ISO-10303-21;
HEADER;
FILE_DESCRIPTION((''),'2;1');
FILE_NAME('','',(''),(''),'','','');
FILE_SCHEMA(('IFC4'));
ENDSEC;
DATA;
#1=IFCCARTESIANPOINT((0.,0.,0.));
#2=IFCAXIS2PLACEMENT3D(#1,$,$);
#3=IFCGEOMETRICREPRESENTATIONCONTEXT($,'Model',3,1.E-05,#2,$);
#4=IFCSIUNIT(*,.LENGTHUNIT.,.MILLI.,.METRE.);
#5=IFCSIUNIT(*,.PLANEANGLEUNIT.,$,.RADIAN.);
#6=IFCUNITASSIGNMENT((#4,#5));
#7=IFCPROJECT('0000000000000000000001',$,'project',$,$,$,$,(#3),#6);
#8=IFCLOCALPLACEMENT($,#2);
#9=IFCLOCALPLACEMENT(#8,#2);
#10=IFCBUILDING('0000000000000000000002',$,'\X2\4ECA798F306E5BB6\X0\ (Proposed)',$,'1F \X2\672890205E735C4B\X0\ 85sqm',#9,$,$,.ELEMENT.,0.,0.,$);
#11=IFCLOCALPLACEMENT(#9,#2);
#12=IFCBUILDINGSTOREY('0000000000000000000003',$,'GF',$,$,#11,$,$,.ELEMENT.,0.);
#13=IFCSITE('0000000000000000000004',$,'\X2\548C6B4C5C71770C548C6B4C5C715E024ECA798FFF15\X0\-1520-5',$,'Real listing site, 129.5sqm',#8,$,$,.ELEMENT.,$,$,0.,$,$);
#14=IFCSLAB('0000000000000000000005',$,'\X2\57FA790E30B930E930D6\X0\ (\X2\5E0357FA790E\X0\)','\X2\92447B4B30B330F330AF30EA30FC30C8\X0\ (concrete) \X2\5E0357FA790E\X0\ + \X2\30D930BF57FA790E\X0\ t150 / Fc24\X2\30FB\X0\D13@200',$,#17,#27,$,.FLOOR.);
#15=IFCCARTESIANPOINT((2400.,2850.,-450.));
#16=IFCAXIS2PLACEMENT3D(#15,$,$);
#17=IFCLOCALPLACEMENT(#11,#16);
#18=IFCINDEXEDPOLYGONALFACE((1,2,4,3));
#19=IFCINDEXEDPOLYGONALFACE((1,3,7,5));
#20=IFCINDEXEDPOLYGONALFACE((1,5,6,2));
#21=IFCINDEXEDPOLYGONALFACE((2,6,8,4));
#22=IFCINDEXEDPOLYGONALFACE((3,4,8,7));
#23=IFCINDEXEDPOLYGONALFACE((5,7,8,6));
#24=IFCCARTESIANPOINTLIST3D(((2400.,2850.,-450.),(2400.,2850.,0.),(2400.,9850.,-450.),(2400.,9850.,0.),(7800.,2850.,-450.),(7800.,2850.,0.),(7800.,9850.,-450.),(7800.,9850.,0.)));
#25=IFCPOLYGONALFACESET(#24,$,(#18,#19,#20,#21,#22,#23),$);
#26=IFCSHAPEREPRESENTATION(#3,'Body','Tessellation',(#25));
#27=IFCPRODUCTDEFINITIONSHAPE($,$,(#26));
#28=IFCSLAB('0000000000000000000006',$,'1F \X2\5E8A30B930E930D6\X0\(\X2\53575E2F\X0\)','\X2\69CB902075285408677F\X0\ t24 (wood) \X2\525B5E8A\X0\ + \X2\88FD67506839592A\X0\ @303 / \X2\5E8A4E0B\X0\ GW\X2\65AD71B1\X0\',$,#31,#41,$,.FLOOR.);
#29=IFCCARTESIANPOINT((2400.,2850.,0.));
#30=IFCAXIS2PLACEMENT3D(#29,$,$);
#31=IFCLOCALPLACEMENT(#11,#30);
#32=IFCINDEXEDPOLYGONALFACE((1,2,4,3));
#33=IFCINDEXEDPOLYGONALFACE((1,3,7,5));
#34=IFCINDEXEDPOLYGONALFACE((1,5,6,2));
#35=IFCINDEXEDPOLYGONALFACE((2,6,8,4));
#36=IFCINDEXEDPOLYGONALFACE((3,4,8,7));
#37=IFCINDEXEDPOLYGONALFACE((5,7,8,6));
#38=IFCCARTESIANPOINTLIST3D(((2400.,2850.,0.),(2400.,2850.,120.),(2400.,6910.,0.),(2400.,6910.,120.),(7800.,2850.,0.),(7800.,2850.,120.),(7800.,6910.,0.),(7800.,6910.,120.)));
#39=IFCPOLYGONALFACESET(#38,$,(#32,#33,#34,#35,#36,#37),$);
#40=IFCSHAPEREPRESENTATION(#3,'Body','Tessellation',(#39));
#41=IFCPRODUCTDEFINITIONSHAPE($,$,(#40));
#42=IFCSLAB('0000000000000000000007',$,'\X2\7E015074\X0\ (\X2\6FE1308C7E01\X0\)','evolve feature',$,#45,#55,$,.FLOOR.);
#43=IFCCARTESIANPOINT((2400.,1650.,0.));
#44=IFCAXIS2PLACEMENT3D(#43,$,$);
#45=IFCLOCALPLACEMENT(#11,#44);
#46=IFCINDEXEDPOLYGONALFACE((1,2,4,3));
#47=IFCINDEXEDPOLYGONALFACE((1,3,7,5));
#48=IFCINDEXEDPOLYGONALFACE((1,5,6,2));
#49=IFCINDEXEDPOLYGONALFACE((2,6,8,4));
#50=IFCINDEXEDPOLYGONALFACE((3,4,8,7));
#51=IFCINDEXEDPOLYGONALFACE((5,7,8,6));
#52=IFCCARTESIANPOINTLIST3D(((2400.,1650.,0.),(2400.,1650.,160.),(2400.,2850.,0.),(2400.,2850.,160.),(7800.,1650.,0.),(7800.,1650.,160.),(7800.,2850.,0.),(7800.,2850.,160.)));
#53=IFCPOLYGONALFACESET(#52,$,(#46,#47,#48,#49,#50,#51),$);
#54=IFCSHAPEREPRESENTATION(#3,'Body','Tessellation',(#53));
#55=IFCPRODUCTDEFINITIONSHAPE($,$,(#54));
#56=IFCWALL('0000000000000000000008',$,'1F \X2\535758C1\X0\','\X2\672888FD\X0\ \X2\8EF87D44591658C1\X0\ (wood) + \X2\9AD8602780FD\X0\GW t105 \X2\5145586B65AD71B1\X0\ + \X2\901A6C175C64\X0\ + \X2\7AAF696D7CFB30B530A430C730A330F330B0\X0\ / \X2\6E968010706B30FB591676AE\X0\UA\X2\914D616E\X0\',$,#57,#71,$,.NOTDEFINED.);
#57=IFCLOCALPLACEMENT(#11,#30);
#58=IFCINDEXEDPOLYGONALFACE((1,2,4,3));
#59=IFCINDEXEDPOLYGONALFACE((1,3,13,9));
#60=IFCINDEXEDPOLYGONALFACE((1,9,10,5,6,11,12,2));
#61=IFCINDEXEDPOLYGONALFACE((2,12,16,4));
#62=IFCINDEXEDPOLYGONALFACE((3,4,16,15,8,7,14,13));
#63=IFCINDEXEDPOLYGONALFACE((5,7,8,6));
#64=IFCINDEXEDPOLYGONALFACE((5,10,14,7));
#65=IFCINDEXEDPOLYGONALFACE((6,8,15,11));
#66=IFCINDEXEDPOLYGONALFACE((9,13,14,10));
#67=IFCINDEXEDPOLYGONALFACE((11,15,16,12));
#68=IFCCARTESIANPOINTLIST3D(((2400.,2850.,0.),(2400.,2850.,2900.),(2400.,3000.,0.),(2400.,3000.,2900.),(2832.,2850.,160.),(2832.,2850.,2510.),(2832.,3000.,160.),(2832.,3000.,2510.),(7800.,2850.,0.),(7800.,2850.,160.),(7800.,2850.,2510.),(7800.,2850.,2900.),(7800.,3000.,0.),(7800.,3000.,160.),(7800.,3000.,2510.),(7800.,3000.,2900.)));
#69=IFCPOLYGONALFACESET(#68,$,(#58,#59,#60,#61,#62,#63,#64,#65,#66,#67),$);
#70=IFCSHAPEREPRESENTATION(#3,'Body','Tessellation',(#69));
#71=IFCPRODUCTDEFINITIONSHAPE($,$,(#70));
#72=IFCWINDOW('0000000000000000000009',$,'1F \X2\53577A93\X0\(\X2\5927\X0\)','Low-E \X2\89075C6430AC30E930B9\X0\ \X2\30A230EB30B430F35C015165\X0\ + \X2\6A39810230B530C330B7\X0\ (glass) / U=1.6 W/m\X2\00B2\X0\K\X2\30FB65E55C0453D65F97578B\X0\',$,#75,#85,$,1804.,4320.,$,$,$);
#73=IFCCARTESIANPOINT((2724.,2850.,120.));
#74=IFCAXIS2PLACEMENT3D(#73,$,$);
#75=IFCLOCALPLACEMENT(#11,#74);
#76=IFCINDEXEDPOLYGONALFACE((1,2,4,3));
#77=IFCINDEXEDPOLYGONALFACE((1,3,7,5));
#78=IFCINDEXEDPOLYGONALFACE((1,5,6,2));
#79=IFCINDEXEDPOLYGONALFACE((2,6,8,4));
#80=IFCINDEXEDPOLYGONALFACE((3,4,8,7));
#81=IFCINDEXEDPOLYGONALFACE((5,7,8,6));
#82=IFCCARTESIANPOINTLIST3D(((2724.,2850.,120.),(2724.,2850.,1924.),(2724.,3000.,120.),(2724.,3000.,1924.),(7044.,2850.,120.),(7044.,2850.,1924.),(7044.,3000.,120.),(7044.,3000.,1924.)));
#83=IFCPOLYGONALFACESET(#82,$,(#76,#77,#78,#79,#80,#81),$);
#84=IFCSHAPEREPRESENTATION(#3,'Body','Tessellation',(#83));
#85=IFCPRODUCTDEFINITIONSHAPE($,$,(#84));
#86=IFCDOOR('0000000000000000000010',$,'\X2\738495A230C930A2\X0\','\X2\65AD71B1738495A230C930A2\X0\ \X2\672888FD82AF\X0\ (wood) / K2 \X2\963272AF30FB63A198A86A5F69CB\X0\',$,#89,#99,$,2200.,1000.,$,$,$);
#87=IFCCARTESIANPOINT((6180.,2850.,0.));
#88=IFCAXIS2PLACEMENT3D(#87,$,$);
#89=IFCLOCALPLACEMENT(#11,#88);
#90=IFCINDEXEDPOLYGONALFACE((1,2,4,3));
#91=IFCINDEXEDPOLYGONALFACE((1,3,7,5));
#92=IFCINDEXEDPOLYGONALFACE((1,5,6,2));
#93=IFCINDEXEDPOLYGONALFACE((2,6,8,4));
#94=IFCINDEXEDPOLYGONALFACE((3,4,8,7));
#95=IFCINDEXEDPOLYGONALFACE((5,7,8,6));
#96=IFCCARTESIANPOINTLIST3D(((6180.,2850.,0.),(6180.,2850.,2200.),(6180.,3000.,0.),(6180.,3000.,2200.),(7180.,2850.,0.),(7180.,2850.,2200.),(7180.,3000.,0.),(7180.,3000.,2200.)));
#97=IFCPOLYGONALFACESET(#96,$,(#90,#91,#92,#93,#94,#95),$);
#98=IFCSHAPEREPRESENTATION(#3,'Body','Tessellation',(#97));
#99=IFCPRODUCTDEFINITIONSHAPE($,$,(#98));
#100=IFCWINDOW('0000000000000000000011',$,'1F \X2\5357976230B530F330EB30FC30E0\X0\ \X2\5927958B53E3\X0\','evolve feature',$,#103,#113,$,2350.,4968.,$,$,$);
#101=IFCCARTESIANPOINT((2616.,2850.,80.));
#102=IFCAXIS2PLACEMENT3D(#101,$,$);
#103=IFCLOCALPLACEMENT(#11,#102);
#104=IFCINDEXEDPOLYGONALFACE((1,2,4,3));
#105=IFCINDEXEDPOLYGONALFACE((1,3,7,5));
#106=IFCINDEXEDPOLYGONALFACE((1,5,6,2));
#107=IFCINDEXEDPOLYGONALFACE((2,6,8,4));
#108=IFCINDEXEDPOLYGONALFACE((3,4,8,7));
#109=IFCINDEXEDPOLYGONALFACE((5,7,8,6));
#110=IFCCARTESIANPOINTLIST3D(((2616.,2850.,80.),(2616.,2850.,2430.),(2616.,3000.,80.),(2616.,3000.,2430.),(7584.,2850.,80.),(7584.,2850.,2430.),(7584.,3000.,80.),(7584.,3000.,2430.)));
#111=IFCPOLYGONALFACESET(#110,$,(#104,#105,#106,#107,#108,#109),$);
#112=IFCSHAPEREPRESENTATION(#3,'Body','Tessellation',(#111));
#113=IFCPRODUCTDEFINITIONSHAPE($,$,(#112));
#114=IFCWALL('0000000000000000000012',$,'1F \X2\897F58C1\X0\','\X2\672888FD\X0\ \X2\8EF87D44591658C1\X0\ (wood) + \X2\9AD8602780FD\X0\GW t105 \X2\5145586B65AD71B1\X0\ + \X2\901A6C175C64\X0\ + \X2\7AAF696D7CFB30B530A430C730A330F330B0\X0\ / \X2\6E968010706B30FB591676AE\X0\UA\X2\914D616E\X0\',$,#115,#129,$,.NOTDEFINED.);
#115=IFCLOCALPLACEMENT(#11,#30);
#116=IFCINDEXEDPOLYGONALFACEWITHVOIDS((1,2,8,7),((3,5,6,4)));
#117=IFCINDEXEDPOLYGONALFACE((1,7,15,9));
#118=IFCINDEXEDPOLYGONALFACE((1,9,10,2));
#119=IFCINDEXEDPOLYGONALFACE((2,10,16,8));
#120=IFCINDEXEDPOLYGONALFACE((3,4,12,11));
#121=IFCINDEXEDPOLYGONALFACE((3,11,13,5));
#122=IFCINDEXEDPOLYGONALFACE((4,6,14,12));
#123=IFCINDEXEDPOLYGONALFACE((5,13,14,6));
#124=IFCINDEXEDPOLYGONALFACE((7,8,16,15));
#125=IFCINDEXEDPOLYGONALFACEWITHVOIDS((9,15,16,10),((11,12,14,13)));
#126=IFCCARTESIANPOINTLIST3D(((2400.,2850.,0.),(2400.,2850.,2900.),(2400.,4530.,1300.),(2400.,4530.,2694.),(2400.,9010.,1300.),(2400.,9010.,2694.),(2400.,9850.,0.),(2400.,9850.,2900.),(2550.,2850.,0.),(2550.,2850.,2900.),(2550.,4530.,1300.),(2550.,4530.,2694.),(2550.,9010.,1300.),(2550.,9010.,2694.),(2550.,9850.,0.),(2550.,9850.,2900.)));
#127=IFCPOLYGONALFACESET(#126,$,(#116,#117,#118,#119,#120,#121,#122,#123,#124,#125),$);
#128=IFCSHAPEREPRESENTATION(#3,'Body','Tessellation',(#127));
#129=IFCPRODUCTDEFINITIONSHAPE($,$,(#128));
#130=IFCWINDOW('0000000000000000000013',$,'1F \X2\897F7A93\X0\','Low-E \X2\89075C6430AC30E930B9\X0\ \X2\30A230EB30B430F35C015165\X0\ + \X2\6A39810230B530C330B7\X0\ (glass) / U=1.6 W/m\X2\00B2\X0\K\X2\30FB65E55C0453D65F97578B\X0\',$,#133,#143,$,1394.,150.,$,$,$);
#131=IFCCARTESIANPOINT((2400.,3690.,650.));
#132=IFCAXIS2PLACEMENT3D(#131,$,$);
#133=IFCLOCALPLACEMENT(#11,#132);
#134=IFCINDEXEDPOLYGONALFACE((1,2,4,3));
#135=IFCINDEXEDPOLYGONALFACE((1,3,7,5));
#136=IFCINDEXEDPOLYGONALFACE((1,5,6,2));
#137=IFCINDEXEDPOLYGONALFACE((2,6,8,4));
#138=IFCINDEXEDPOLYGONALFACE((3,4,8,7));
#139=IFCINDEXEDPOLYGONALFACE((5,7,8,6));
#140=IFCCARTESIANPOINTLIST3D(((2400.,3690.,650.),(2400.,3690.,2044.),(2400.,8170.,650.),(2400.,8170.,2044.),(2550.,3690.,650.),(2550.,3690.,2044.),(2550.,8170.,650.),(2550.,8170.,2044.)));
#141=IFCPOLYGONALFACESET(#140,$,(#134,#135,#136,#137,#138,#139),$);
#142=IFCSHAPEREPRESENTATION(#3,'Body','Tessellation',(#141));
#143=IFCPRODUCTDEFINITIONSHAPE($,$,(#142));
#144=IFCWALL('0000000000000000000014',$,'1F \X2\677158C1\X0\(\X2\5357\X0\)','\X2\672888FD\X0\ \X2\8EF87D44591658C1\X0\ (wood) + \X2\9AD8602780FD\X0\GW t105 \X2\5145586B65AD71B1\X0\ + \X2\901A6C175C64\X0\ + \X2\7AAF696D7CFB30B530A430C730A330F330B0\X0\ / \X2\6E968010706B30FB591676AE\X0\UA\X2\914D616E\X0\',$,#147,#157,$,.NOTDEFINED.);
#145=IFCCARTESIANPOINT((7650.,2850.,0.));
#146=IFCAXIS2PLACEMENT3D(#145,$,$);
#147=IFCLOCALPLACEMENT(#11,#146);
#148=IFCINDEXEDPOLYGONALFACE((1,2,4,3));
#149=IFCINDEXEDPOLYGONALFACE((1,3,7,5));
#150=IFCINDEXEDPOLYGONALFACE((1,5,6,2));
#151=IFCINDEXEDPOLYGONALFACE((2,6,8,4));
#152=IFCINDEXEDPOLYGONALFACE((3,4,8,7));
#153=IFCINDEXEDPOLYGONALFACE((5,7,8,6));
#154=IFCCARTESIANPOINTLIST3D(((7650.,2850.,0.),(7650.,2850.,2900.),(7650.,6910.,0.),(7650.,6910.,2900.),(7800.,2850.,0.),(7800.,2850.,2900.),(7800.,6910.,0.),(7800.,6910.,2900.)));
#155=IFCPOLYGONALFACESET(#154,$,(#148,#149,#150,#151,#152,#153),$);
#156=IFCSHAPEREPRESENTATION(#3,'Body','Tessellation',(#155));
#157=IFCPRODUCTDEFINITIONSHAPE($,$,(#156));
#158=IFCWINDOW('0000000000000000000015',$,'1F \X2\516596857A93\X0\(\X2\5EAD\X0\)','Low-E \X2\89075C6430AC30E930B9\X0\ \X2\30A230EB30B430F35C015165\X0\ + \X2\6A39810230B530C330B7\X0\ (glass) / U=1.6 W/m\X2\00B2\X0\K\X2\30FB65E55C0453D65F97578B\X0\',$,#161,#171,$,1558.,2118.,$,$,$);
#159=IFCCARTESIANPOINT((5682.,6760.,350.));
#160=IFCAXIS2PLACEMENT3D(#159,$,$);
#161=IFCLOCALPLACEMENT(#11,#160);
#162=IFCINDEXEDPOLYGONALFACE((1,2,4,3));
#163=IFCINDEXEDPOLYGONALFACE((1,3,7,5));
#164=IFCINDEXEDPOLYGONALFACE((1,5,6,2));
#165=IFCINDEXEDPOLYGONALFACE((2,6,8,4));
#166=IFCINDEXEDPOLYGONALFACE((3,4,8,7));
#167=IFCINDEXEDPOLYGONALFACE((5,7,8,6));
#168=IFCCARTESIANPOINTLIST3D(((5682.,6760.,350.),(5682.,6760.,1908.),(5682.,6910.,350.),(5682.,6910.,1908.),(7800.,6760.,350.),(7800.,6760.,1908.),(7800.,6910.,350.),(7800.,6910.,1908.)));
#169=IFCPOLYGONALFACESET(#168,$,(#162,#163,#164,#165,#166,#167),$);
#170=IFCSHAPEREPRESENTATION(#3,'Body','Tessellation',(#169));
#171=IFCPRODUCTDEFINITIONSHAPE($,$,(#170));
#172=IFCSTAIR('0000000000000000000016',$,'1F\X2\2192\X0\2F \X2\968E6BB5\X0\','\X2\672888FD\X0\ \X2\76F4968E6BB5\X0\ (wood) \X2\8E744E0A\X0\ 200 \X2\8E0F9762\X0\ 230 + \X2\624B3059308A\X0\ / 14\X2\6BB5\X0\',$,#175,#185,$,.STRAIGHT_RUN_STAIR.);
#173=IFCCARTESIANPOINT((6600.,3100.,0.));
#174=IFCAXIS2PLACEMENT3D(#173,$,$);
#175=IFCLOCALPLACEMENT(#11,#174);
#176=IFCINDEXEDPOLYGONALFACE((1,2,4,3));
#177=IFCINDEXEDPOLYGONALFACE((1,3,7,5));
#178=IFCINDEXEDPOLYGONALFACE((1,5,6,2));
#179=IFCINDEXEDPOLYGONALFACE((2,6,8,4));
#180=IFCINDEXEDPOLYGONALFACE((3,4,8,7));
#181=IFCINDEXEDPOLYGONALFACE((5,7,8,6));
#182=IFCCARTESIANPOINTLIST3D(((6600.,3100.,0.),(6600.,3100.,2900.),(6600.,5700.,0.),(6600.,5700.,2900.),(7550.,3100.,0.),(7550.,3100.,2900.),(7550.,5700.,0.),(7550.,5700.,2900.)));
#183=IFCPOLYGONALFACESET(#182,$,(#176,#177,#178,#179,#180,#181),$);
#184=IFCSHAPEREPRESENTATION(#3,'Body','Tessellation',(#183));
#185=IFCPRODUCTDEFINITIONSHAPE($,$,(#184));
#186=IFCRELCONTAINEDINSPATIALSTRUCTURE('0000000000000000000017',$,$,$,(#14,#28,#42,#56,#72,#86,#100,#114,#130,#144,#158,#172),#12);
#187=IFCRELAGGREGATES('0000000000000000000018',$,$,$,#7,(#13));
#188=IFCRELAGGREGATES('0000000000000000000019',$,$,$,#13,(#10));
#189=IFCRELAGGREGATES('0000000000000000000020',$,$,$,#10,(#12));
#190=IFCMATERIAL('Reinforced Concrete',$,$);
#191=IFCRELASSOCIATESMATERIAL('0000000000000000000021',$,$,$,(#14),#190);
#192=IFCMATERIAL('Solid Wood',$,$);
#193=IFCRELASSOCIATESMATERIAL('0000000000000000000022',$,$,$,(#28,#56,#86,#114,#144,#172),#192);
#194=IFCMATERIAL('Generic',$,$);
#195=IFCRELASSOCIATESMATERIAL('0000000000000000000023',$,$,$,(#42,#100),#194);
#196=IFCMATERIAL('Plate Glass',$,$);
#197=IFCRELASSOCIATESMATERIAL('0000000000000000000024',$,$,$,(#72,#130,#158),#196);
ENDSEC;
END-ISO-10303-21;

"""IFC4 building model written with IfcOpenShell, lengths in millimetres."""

from ifc_helpers import new_model, si_unit, frame, frame_2d, origin, place, context, project, spatial, rectangle, extrude, material, element, fill, save


model = new_model("IFC4")

# Units and contexts
model_context = context("Model", 3, precision=1e-05, world=origin())
ifc_project = project(units=[si_unit("LENGTHUNIT", "METRE", prefix="MILLI"), si_unit("PLANEANGLEUNIT", "RADIAN")], contexts=[model_context])

# Site, building, storey
site_placement = place(None, origin())
site = spatial("IfcSite", under=ifc_project, at=site_placement, Name="和歌山県和歌山市今福５-1520-5", ObjectType="Real listing site, 129.5sqm", CompositionType="ELEMENT", RefElevation=0.0)
building_placement = place(site_placement, origin())
building = spatial("IfcBuilding", under=site, at=building_placement, Name="今福の家 (Proposed)", ObjectType="1F 木造平屋 85sqm", CompositionType="ELEMENT", ElevationOfRefHeight=0.0, ElevationOfTerrain=0.0)
storey_placement = place(building_placement, origin())
storey = spatial("IfcBuildingStorey", under=building, at=storey_placement, Name="GF", CompositionType="ELEMENT", Elevation=0.0)

# Slabs
ifc_material_1 = material(Name="Reinforced Concrete")
slab_1_placement = place(storey_placement, frame((2400.0, 2850.0, -450.0)))
element("IfcSlab", 1, at=slab_1_placement, inside=storey, material=ifc_material_1, Name="基礎スラブ (布基礎)", Description="鉄筋コンクリート (concrete) 布基礎 + ベタ基礎 t150 / Fc24・D13@200", PredefinedType="FLOOR", context=model_context, shape_type="SweptSolid", body=[
    extrude(rectangle(XDim=5400.0, YDim=7000.0, at=frame_2d((2700.0, 3500.0))), frame((2400.0, 2850.0, -450.0)), (0.0, 0.0, 1.0), 450.0),
])
ifc_material_2 = material(Name="Solid Wood")
slab_2_placement = place(storey_placement, frame((2400.0, 2850.0, 0.0)))
element("IfcSlab", 2, at=slab_2_placement, inside=storey, material=ifc_material_2, Name="1F 床スラブ(南帯)", Description="構造用合板 t24 (wood) 剛床 + 製材根太 @303 / 床下 GW断熱", PredefinedType="FLOOR", context=model_context, shape_type="SweptSolid", body=[
    extrude(rectangle(XDim=5400.0, YDim=4060.0, at=frame_2d((2700.0, 2030.0))), frame((2400.0, 2850.0, 0.0)), (0.0, 0.0, 1.0), 120.0),
])
ifc_material_3 = material(Name="Generic")
slab_3_placement = place(storey_placement, frame((2400.0, 1650.0, 0.0)))
element("IfcSlab", 3, at=slab_3_placement, inside=storey, material=ifc_material_3, Name="縁側 (濡れ縁)", Description="evolve feature", PredefinedType="FLOOR", context=model_context, shape_type="SweptSolid", body=[
    extrude(rectangle(XDim=5400.0, YDim=1200.0, at=frame_2d((2700.0, 600.0))), frame((2400.0, 1650.0, 0.0)), (0.0, 0.0, 1.0), 160.0),
])

# Wall, openings, windows, door
wall_1_placement = place(storey_placement, frame((2400.0, 2850.0, 0.0)))
wall_1 = element("IfcWall", 4, at=wall_1_placement, inside=storey, material=ifc_material_2, Name="1F 南壁", Description="木製 軸組外壁 (wood) + 高性能GW t105 充填断熱 + 通気層 + 窯業系サイディング / 準耐火・外皮UA配慮", PredefinedType="NOTDEFINED", context=model_context, shape_type="SweptSolid", body=[
    extrude(rectangle(XDim=5400.0, YDim=150.0, at=frame_2d((2700.0, 75.0))), frame((2400.0, 2850.0, 0.0)), (0.0, 0.0, 1.0), 2900.0),
])
opening_1_placement = place(storey_placement, frame((2724.0, 2850.0, 120.0)))
opening_1 = element("IfcOpeningElement", 5, at=opening_1_placement, cuts=wall_1, PredefinedType="NOTDEFINED", context=model_context, shape_type="SweptSolid", body=[
    extrude(rectangle(XDim=4320.0, YDim=150.0, at=frame_2d((2160.0, 75.0))), frame((2724.0, 2850.0, 120.0)), (0.0, 0.0, 1.0), 1804.0),
])
opening_2_placement = place(storey_placement, frame((6180.0, 2850.0, 0.0)))
opening_2 = element("IfcOpeningElement", 6, at=opening_2_placement, cuts=wall_1, PredefinedType="NOTDEFINED", context=model_context, shape_type="SweptSolid", body=[
    extrude(rectangle(XDim=1000.0, YDim=150.0, at=frame_2d((500.0, 75.0))), frame((6180.0, 2850.0, 0.0)), (0.0, 0.0, 1.0), 2200.0),
])
opening_3_placement = place(storey_placement, frame((2616.0, 2850.0, 80.0)))
opening_3 = element("IfcOpeningElement", 7, at=opening_3_placement, cuts=wall_1, PredefinedType="NOTDEFINED", context=model_context, shape_type="SweptSolid", body=[
    extrude(rectangle(XDim=4968.0, YDim=150.0, at=frame_2d((2484.0, 75.0))), frame((2616.0, 2850.0, 80.0)), (0.0, 0.0, 1.0), 2350.0),
])
ifc_material_4 = material(Name="Plate Glass")
window_1_placement = place(storey_placement, frame((2724.0, 2850.0, 120.0)))
window_1 = element("IfcWindow", 8, at=window_1_placement, inside=storey, material=ifc_material_4, Name="1F 南窓(大)", Description="Low-E 複層ガラス アルゴン封入 + 樹脂サッシ (glass) / U=1.6 W/m²K・日射取得型", OverallHeight=1804.0, OverallWidth=4320.0, context=model_context, shape_type="SweptSolid", body=[
    extrude(rectangle(XDim=4320.0, YDim=150.0, at=frame_2d((2160.0, 75.0))), frame((2724.0, 2850.0, 120.0)), (0.0, 0.0, 1.0), 1804.0),
])
fill(opening_1, window_1)
door_1_placement = place(storey_placement, frame((6180.0, 2850.0, 0.0)))
door_1 = element("IfcDoor", 9, at=door_1_placement, inside=storey, material=ifc_material_2, Name="玄関ドア", Description="断熱玄関ドア 木製芯 (wood) / K2 防犯・採風機構", OverallHeight=2200.0, OverallWidth=1000.0, context=model_context, shape_type="SweptSolid", body=[
    extrude(rectangle(XDim=1000.0, YDim=150.0, at=frame_2d((500.0, 75.0))), frame((6180.0, 2850.0, 0.0)), (0.0, 0.0, 1.0), 2200.0),
])
fill(opening_2, door_1)
window_2_placement = place(storey_placement, frame((2616.0, 2850.0, 80.0)))
window_2 = element("IfcWindow", 10, at=window_2_placement, inside=storey, material=ifc_material_3, Name="1F 南面サンルーム 大開口", Description="evolve feature", OverallHeight=2350.0, OverallWidth=4968.0, context=model_context, shape_type="SweptSolid", body=[
    extrude(rectangle(XDim=4968.0, YDim=150.0, at=frame_2d((2484.0, 75.0))), frame((2616.0, 2850.0, 80.0)), (0.0, 0.0, 1.0), 2350.0),
])
fill(opening_3, window_2)

# Walls, openings, windows
wall_2_placement = place(storey_placement, frame((2400.0, 2850.0, 0.0)))
wall_2 = element("IfcWall", 11, at=wall_2_placement, inside=storey, material=ifc_material_2, Name="1F 西壁", Description="木製 軸組外壁 (wood) + 高性能GW t105 充填断熱 + 通気層 + 窯業系サイディング / 準耐火・外皮UA配慮", PredefinedType="NOTDEFINED", context=model_context, shape_type="SweptSolid", body=[
    extrude(rectangle(XDim=150.0, YDim=7000.0, at=frame_2d((75.0, 3500.0))), frame((2400.0, 2850.0, 0.0)), (0.0, 0.0, 1.0), 2900.0),
])
opening_4_placement = place(storey_placement, frame((2400.0, 3690.0, 650.0)))
opening_4 = element("IfcOpeningElement", 12, at=opening_4_placement, cuts=wall_2, PredefinedType="NOTDEFINED", context=model_context, shape_type="SweptSolid", body=[
    extrude(rectangle(XDim=150.0, YDim=4480.0, at=frame_2d((75.0, 2240.0))), frame((2400.0, 3690.0, 650.0)), (0.0, 0.0, 1.0), 1394.0),
])
window_3_placement = place(storey_placement, frame((2400.0, 3690.0, 650.0)))
window_3 = element("IfcWindow", 13, at=window_3_placement, inside=storey, material=ifc_material_4, Name="1F 西窓", Description="Low-E 複層ガラス アルゴン封入 + 樹脂サッシ (glass) / U=1.6 W/m²K・日射取得型", OverallHeight=1394.0, OverallWidth=150.0, context=model_context, shape_type="SweptSolid", body=[
    extrude(rectangle(XDim=150.0, YDim=4480.0, at=frame_2d((75.0, 2240.0))), frame((2400.0, 3690.0, 650.0)), (0.0, 0.0, 1.0), 1394.0),
])
fill(opening_4, window_3)
wall_3_placement = place(storey_placement, frame((7650.0, 2850.0, 0.0)))
wall_3 = element("IfcWall", 14, at=wall_3_placement, inside=storey, material=ifc_material_2, Name="1F 東壁(南)", Description="木製 軸組外壁 (wood) + 高性能GW t105 充填断熱 + 通気層 + 窯業系サイディング / 準耐火・外皮UA配慮", PredefinedType="NOTDEFINED", context=model_context, shape_type="SweptSolid", body=[
    extrude(rectangle(XDim=150.0, YDim=4060.0, at=frame_2d((75.0, 2030.0))), frame((7650.0, 2850.0, 0.0)), (0.0, 0.0, 1.0), 2900.0),
])
opening_5_placement = place(storey_placement, frame((5682.0, 6760.0, 350.0)))
opening_5 = element("IfcOpeningElement", 15, at=opening_5_placement, cuts=wall_3, PredefinedType="NOTDEFINED", context=model_context, shape_type="SweptSolid", body=[
    extrude(rectangle(XDim=2118.0, YDim=150.0, at=frame_2d((1059.0, 75.0))), frame((5682.0, 6760.0, 350.0)), (0.0, 0.0, 1.0), 1558.0),
])
window_4_placement = place(storey_placement, frame((5682.0, 6760.0, 350.0)))
window_4 = element("IfcWindow", 16, at=window_4_placement, inside=storey, material=ifc_material_4, Name="1F 入隅窓(庭)", Description="Low-E 複層ガラス アルゴン封入 + 樹脂サッシ (glass) / U=1.6 W/m²K・日射取得型", OverallHeight=1558.0, OverallWidth=2118.0, context=model_context, shape_type="SweptSolid", body=[
    extrude(rectangle(XDim=2118.0, YDim=150.0, at=frame_2d((1059.0, 75.0))), frame((5682.0, 6760.0, 350.0)), (0.0, 0.0, 1.0), 1558.0),
])
fill(opening_5, window_4)

# Stair
stair_placement = place(storey_placement, frame((6600.0, 3100.0, 0.0)))
element("IfcStair", 17, at=stair_placement, inside=storey, material=ifc_material_2, Name="1F→2F 階段", Description="木製 直階段 (wood) 蹴上 200 踏面 230 + 手すり / 14段", PredefinedType="STRAIGHT_RUN_STAIR", context=model_context, shape_type="SweptSolid", body=[
    extrude(rectangle(XDim=950.0, YDim=2600.0, at=frame_2d((475.0, 1300.0))), frame((6600.0, 3100.0, 0.0)), (0.0, 0.0, 1.0), 2900.0),
])

save(model, "model.ifc")
